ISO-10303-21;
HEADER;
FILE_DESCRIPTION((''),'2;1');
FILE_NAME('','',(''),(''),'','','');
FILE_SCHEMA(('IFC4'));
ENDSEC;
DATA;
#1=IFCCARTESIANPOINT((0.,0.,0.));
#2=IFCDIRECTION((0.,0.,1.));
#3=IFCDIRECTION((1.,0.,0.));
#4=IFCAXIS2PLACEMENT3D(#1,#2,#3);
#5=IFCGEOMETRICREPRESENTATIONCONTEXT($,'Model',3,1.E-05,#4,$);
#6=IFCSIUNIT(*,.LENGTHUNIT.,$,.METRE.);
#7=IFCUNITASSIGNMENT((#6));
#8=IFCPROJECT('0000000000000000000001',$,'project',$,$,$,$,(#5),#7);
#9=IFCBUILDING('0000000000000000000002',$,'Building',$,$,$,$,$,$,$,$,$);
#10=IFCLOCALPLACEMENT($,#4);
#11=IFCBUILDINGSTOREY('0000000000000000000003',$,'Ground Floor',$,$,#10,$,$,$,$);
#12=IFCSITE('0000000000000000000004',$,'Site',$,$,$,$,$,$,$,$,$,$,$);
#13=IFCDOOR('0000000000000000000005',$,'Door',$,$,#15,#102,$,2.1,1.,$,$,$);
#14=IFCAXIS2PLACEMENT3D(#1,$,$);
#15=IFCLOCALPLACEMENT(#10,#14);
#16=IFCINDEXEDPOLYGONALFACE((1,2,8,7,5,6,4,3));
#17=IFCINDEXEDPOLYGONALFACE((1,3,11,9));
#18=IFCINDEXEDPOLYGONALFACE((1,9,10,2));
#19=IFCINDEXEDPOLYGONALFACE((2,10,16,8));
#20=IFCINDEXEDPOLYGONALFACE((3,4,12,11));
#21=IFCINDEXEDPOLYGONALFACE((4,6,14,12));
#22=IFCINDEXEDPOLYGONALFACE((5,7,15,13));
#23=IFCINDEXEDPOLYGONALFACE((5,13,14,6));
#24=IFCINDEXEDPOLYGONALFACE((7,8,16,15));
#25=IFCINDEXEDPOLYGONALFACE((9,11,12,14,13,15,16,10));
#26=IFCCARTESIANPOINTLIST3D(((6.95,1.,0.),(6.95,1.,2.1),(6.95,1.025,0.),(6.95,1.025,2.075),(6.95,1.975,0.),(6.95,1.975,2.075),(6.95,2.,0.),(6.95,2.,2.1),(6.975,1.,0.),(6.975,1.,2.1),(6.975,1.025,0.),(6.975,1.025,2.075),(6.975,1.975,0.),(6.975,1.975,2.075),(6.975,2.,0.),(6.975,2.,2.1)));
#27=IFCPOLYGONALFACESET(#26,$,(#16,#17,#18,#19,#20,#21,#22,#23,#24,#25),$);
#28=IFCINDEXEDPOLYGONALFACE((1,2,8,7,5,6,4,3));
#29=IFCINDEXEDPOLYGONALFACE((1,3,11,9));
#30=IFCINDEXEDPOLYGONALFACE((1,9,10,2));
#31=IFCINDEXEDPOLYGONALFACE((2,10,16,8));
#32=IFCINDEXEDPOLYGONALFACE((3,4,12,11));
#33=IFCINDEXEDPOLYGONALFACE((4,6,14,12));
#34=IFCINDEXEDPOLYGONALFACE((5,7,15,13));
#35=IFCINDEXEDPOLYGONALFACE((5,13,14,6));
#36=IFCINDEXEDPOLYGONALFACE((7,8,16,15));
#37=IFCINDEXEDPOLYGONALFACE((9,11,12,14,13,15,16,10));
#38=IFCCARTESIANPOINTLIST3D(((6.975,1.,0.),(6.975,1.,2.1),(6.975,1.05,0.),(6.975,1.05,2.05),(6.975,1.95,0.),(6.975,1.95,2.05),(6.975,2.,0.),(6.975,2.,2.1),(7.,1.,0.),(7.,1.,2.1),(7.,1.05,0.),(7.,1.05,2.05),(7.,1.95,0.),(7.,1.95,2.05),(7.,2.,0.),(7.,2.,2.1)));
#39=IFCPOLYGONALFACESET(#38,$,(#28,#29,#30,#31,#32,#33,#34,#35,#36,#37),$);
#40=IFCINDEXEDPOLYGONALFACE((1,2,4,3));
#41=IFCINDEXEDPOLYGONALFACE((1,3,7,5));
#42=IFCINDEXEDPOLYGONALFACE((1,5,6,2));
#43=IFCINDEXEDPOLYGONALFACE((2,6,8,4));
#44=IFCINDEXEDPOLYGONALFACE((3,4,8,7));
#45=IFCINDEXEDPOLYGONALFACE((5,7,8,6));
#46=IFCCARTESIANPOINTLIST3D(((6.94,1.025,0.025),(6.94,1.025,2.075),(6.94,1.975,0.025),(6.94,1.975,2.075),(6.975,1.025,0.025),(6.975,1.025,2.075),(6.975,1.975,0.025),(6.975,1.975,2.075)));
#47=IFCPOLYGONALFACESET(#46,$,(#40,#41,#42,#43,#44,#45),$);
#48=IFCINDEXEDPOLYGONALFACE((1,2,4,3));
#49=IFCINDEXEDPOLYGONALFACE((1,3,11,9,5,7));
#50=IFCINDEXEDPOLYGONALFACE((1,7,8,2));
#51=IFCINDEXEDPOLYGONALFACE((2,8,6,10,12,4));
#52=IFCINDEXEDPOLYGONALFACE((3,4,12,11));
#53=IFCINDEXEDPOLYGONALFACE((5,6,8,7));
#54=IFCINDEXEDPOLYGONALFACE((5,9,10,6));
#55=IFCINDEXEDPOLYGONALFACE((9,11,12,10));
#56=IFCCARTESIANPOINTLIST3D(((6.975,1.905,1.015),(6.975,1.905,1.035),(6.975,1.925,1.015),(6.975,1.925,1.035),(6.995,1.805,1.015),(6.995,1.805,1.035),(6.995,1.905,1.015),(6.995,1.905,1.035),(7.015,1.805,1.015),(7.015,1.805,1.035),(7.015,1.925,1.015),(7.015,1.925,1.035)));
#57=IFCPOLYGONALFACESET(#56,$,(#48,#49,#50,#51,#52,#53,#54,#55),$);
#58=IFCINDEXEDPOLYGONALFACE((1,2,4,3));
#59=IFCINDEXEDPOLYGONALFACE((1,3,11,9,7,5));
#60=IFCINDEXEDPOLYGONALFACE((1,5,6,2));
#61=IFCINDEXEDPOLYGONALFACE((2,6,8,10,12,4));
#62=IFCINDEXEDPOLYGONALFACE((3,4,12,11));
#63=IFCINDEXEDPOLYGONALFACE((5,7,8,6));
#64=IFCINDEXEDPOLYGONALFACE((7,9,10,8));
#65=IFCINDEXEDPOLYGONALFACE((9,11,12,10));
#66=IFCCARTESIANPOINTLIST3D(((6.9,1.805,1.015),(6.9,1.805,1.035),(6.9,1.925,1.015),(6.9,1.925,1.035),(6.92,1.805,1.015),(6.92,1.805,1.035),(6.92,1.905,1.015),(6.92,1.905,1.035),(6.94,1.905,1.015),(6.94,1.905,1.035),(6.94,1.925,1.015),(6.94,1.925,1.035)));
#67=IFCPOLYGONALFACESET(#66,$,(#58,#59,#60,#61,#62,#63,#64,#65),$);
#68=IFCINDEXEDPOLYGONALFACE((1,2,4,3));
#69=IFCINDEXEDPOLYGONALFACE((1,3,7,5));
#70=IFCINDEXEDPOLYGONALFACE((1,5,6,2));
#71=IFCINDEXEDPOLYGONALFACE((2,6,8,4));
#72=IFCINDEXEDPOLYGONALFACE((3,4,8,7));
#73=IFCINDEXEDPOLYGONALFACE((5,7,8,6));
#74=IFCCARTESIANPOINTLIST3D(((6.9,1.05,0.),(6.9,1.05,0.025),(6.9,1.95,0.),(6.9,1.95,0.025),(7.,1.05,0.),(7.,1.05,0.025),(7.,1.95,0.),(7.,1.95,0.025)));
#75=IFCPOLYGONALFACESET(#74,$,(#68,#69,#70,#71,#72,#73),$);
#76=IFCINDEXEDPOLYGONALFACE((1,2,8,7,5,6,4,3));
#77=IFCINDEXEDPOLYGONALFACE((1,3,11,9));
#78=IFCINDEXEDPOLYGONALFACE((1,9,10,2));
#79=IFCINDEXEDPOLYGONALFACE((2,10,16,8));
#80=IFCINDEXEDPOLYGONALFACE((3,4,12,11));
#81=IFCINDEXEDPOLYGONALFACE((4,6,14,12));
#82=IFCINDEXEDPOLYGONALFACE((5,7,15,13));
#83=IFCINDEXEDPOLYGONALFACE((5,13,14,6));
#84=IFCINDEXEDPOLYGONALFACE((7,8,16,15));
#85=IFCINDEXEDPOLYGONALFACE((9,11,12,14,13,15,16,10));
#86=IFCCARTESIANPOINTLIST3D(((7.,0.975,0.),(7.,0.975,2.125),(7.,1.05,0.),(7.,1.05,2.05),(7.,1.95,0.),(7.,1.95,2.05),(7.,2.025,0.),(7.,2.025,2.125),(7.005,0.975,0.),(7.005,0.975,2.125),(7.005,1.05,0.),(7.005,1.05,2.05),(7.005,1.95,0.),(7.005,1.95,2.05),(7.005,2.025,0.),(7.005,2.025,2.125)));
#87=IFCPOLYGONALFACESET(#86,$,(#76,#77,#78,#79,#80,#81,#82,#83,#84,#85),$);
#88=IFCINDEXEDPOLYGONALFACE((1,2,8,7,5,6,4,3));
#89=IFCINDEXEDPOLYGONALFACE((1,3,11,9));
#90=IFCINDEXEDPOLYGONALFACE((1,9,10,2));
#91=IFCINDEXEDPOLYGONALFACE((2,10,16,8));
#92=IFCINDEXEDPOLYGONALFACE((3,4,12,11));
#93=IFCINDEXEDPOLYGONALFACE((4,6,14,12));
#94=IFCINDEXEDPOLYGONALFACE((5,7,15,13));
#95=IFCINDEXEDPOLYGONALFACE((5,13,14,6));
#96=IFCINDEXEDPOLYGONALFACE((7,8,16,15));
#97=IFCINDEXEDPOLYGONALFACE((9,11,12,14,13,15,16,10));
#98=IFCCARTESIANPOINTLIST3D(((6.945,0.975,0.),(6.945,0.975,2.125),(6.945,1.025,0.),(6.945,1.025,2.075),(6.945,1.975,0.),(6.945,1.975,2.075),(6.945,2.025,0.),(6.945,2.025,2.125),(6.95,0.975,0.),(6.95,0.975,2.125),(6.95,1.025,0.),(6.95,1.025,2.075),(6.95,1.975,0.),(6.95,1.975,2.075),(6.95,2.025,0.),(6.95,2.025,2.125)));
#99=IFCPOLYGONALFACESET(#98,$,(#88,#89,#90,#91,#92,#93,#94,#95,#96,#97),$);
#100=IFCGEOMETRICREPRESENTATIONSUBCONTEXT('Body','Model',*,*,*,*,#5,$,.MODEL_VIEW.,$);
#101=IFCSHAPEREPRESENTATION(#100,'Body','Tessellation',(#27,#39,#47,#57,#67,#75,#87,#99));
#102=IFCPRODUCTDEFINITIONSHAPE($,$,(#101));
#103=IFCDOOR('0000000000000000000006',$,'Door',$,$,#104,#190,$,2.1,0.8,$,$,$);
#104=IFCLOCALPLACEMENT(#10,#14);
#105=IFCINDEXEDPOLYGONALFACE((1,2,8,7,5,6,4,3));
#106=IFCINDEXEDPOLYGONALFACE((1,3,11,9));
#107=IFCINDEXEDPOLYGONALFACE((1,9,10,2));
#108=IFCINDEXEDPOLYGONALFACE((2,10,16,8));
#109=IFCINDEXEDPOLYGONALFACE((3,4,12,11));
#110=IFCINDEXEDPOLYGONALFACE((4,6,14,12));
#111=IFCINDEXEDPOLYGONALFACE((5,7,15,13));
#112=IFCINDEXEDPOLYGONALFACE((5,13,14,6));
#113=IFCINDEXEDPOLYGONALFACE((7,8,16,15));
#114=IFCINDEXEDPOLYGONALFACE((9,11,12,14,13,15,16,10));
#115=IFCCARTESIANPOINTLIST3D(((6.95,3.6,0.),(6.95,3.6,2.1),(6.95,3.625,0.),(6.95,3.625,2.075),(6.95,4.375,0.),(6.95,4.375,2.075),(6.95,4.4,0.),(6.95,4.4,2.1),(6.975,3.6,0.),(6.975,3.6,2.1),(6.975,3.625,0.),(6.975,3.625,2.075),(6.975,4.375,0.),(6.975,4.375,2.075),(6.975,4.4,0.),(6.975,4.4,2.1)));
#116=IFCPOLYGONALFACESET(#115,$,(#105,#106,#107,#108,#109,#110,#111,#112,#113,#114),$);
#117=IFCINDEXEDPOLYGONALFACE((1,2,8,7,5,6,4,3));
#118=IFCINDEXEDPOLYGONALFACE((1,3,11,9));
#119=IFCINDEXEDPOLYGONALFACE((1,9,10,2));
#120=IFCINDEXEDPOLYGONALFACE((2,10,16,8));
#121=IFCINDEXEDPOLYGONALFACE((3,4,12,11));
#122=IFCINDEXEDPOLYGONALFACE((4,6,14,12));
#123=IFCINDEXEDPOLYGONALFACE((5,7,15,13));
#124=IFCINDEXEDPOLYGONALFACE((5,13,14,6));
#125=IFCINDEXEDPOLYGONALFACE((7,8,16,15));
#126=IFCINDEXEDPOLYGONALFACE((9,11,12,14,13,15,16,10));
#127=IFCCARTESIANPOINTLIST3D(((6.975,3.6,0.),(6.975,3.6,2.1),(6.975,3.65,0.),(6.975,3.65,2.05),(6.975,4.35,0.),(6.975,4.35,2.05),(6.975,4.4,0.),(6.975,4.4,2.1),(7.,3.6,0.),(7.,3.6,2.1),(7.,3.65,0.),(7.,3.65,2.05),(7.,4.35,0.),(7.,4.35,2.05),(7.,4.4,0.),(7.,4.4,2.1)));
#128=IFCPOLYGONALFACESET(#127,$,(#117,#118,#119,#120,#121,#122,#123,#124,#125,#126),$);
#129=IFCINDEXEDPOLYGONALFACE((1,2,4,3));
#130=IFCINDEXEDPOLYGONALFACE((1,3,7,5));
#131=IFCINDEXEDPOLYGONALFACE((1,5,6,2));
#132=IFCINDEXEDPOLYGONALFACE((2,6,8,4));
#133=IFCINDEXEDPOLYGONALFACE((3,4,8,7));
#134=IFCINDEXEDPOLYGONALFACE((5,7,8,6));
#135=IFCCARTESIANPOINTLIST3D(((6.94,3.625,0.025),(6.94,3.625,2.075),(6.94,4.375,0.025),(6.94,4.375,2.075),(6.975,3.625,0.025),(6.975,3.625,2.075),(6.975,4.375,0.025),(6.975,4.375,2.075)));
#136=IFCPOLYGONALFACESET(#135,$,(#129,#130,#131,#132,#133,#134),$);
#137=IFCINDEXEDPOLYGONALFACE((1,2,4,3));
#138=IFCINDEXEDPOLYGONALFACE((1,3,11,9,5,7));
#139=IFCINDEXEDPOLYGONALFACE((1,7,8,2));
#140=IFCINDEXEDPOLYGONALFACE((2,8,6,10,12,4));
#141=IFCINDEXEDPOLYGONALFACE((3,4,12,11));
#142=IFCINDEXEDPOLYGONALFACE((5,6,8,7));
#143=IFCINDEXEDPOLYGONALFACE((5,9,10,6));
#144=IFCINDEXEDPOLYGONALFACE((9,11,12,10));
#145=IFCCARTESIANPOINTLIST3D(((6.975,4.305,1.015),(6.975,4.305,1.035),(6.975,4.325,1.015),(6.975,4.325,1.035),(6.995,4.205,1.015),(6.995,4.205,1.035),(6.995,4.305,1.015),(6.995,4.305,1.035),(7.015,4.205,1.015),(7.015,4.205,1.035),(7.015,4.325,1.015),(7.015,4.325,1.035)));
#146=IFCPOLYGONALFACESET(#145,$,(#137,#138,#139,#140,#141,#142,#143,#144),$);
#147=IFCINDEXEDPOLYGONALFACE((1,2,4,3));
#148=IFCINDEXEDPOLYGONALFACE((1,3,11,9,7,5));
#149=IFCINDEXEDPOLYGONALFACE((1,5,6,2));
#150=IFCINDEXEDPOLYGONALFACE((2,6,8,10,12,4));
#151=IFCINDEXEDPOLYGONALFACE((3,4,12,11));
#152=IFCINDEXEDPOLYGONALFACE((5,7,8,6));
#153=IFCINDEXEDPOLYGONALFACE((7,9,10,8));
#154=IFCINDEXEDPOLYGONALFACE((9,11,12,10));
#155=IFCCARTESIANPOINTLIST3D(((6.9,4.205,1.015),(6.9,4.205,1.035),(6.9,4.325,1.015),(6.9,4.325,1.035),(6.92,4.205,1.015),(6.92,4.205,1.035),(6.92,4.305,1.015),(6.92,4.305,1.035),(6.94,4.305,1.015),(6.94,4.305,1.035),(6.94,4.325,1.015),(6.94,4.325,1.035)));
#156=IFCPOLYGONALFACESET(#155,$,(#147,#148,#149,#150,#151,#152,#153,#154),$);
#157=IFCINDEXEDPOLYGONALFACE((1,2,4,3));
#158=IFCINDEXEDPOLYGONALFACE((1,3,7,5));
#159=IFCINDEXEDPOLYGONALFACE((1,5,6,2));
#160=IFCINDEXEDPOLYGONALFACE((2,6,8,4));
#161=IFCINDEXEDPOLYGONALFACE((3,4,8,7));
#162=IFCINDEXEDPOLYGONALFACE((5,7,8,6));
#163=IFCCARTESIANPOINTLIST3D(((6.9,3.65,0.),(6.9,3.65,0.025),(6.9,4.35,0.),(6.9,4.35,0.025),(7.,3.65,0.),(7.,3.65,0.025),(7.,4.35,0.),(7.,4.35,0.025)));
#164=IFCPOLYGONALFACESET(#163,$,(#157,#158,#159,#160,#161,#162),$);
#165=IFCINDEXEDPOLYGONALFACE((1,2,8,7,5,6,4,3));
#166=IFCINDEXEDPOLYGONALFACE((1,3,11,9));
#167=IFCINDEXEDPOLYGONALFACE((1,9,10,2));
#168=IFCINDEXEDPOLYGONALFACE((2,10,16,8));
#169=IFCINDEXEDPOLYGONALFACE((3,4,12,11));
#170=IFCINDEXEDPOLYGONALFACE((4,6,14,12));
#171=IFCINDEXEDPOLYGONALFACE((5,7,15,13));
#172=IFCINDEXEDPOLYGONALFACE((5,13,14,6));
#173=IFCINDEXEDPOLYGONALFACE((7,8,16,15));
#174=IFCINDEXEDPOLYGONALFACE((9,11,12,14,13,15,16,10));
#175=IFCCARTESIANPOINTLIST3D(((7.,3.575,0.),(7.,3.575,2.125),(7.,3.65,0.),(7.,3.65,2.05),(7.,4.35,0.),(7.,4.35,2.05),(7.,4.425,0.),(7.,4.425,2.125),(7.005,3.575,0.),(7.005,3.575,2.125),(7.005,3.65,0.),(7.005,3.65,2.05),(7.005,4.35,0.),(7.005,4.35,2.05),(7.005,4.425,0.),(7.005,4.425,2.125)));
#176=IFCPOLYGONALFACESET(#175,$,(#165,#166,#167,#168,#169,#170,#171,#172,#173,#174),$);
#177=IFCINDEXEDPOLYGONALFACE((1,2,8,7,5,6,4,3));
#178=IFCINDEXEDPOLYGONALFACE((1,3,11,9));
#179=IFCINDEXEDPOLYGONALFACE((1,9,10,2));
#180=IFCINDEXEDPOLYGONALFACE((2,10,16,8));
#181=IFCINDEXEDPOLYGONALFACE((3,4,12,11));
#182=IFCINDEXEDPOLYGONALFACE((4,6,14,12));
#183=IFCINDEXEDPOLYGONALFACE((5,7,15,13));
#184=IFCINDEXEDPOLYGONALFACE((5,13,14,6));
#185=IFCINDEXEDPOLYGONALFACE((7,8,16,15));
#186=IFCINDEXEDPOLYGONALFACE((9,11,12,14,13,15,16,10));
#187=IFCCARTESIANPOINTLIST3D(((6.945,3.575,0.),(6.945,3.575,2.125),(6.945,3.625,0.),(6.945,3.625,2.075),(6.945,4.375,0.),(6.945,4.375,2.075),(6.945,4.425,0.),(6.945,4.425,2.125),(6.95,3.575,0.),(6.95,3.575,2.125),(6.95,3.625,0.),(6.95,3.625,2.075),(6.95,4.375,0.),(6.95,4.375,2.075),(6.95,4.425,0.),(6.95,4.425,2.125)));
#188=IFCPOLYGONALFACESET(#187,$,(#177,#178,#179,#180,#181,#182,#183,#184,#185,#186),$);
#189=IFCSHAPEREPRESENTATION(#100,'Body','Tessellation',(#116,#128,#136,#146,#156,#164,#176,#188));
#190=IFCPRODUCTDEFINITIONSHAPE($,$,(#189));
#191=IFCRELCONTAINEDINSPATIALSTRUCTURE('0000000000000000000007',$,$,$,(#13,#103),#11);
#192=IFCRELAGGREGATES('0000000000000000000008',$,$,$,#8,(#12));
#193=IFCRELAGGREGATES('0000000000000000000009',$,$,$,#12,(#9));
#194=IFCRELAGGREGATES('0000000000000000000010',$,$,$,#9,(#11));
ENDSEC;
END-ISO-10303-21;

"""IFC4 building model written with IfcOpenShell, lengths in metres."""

from ifc_helpers import new_model, si_unit, frame, origin_with_axes, place, context, subcontext, project, spatial, line, indexed_curve, outline, extrude, element, save


model = new_model("IFC4")

# Units and contexts
model_context = context("Model", 3, precision=1e-05, world=origin_with_axes())
body_context = subcontext(model_context, "Body", "Model", "MODEL_VIEW")
ifc_project = project(units=[si_unit("LENGTHUNIT", "METRE")], contexts=[model_context])

# Site, building, storey
site = spatial("IfcSite", under=ifc_project, Name="Site")
building = spatial("IfcBuilding", under=site, Name="Building")
storey_placement = place(None, origin_with_axes())
storey = spatial("IfcBuildingStorey", under=building, at=storey_placement, Name="Ground Floor")

# Doors
door_1_placement = place(storey_placement, frame((7.0, 1.0, 0.0), z_axis=(0.0, 0.0, 1.0), x_axis=(0.0, 1.0, 0.0)))
element("IfcDoor", 1, at=door_1_placement, inside=storey, Name="Door", OverallHeight=2.1, OverallWidth=1.0, context=body_context, shape_type="SweptSolid", body=[
    extrude(outline(indexed_curve([(0.0, 0.0), (0.0, 2.1), (1.0, 2.1), (1.0, 0.0), (0.975, 0.0), (0.975, 2.075), (0.025, 2.075), (0.025, 0.0)], segments=[line(1, 2, 3, 4, 5, 6, 7, 8, 1)])), frame((0.0, 0.025, 0.0), z_axis=(0.0, -1.0, 0.0), x_axis=(1.0, 0.0, 0.0)), (0.0, 0.0, -1.0), 0.025),
    extrude(outline(indexed_curve([(0.0, 0.0), (0.0, 2.1), (1.0, 2.1), (1.0, 0.0), (0.95, 0.0), (0.95, 2.05), (0.05, 2.05), (0.05, 0.0)], segments=[line(1, 2, 3, 4, 5, 6, 7, 8, 1)])), frame((0.0, 0.0, 0.0), z_axis=(0.0, -1.0, 0.0), x_axis=(1.0, 0.0, 0.0)), (0.0, 0.0, -1.0), 0.025),
    extrude(outline(indexed_curve([(0.0, 0.0), (0.95, 0.0), (0.95, 0.035), (0.0, 0.035)], segments=[line(1, 2, 3, 4, 1)])), frame((0.025, 0.025, 0.025), z_axis=(0.0, 0.0, 1.0), x_axis=(1.0, 0.0, 0.0)), (0.0, 0.0, 1.0), 2.05),
    extrude(outline(indexed_curve([(0.0, 0.0), (0.0, -0.04), (-0.12, -0.04), (-0.12, -0.02), (-0.02, -0.02), (-0.02, 0.0)], segments=[line(1, 2, 3, 4, 5, 6, 1)])), frame((0.925, 0.025, 1.015), z_axis=(0.0, 0.0, 1.0), x_axis=(1.0, 0.0, 0.0)), (0.0, 0.0, 1.0), 0.02),
    extrude(outline(indexed_curve([(0.0, 0.0), (0.0, 0.04), (-0.12, 0.04), (-0.12, 0.02), (-0.02, 0.02), (-0.02, 0.0)], segments=[line(1, 2, 3, 4, 5, 6, 1)])), frame((0.925, 0.06, 1.015), z_axis=(0.0, 0.0, 1.0), x_axis=(1.0, 0.0, 0.0)), (0.0, 0.0, 1.0), 0.02),
    extrude(outline(indexed_curve([(0.0, 0.0), (0.9, 0.0), (0.9, 0.1), (0.0, 0.1)], segments=[line(1, 2, 3, 4, 1)])), frame((0.05, 0.0, 0.0), z_axis=(0.0, 0.0, 1.0), x_axis=(1.0, 0.0, 0.0)), (0.0, 0.0, 1.0), 0.025),
    extrude(outline(indexed_curve([(0.0, 0.0), (0.0, 2.125), (1.05, 2.125), (1.05, 0.0), (0.975, 0.0), (0.975, 2.05), (0.075, 2.05), (0.075, 0.0)], segments=[line(1, 2, 3, 4, 5, 6, 7, 8, 1)])), frame((-0.025, -0.005, 0.0), z_axis=(0.0, -1.0, 0.0), x_axis=(1.0, 0.0, 0.0)), (0.0, 0.0, -1.0), 0.005),
    extrude(outline(indexed_curve([(0.0, 0.0), (0.0, 2.125), (1.05, 2.125), (1.05, 0.0), (1.0, 0.0), (1.0, 2.075), (0.05, 2.075), (0.05, 0.0)], segments=[line(1, 2, 3, 4, 5, 6, 7, 8, 1)])), frame((-0.025, 0.05, 0.0), z_axis=(0.0, -1.0, 0.0), x_axis=(1.0, 0.0, 0.0)), (0.0, 0.0, -1.0), 0.005),
])
door_2_placement = place(storey_placement, frame((7.0, 3.6, 0.0), z_axis=(0.0, 0.0, 1.0), x_axis=(0.0, 1.0, 0.0)))
element("IfcDoor", 2, at=door_2_placement, inside=storey, Name="Door", OverallHeight=2.1, OverallWidth=0.8, context=body_context, shape_type="SweptSolid", body=[
    extrude(outline(indexed_curve([(0.0, 0.0), (0.0, 2.1), (0.8, 2.1), (0.8, 0.0), (0.775, 0.0), (0.775, 2.075), (0.025, 2.075), (0.025, 0.0)], segments=[line(1, 2, 3, 4, 5, 6, 7, 8, 1)])), frame((0.0, 0.025, 0.0), z_axis=(0.0, -1.0, 0.0), x_axis=(1.0, 0.0, 0.0)), (0.0, 0.0, -1.0), 0.025),
    extrude(outline(indexed_curve([(0.0, 0.0), (0.0, 2.1), (0.8, 2.1), (0.8, 0.0), (0.75, 0.0), (0.75, 2.05), (0.05, 2.05), (0.05, 0.0)], segments=[line(1, 2, 3, 4, 5, 6, 7, 8, 1)])), frame((0.0, 0.0, 0.0), z_axis=(0.0, -1.0, 0.0), x_axis=(1.0, 0.0, 0.0)), (0.0, 0.0, -1.0), 0.025),
    extrude(outline(indexed_curve([(0.0, 0.0), (0.75, 0.0), (0.75, 0.035), (0.0, 0.035)], segments=[line(1, 2, 3, 4, 1)])), frame((0.025, 0.025, 0.025), z_axis=(0.0, 0.0, 1.0), x_axis=(1.0, 0.0, 0.0)), (0.0, 0.0, 1.0), 2.05),
    extrude(outline(indexed_curve([(0.0, 0.0), (0.0, -0.04), (-0.12, -0.04), (-0.12, -0.02), (-0.02, -0.02), (-0.02, 0.0)], segments=[line(1, 2, 3, 4, 5, 6, 1)])), frame((0.725, 0.025, 1.015), z_axis=(0.0, 0.0, 1.0), x_axis=(1.0, 0.0, 0.0)), (0.0, 0.0, 1.0), 0.02),
    extrude(outline(indexed_curve([(0.0, 0.0), (0.0, 0.04), (-0.12, 0.04), (-0.12, 0.02), (-0.02, 0.02), (-0.02, 0.0)], segments=[line(1, 2, 3, 4, 5, 6, 1)])), frame((0.725, 0.06, 1.015), z_axis=(0.0, 0.0, 1.0), x_axis=(1.0, 0.0, 0.0)), (0.0, 0.0, 1.0), 0.02),
    extrude(outline(indexed_curve([(0.0, 0.0), (0.7, 0.0), (0.7, 0.1), (0.0, 0.1)], segments=[line(1, 2, 3, 4, 1)])), frame((0.05, 0.0, 0.0), z_axis=(0.0, 0.0, 1.0), x_axis=(1.0, 0.0, 0.0)), (0.0, 0.0, 1.0), 0.025),
    extrude(outline(indexed_curve([(0.0, 0.0), (0.0, 2.125), (0.85, 2.125), (0.85, 0.0), (0.775, 0.0), (0.775, 2.05), (0.075, 2.05), (0.075, 0.0)], segments=[line(1, 2, 3, 4, 5, 6, 7, 8, 1)])), frame((-0.025, -0.005, 0.0), z_axis=(0.0, -1.0, 0.0), x_axis=(1.0, 0.0, 0.0)), (0.0, 0.0, -1.0), 0.005),
    extrude(outline(indexed_curve([(0.0, 0.0), (0.0, 2.125), (0.85, 2.125), (0.85, 0.0), (0.8, 0.0), (0.8, 2.075), (0.05, 2.075), (0.05, 0.0)], segments=[line(1, 2, 3, 4, 5, 6, 7, 8, 1)])), frame((-0.025, 0.05, 0.0), z_axis=(0.0, -1.0, 0.0), x_axis=(1.0, 0.0, 0.0)), (0.0, 0.0, -1.0), 0.005),
])

save(model, "model.ifc")
